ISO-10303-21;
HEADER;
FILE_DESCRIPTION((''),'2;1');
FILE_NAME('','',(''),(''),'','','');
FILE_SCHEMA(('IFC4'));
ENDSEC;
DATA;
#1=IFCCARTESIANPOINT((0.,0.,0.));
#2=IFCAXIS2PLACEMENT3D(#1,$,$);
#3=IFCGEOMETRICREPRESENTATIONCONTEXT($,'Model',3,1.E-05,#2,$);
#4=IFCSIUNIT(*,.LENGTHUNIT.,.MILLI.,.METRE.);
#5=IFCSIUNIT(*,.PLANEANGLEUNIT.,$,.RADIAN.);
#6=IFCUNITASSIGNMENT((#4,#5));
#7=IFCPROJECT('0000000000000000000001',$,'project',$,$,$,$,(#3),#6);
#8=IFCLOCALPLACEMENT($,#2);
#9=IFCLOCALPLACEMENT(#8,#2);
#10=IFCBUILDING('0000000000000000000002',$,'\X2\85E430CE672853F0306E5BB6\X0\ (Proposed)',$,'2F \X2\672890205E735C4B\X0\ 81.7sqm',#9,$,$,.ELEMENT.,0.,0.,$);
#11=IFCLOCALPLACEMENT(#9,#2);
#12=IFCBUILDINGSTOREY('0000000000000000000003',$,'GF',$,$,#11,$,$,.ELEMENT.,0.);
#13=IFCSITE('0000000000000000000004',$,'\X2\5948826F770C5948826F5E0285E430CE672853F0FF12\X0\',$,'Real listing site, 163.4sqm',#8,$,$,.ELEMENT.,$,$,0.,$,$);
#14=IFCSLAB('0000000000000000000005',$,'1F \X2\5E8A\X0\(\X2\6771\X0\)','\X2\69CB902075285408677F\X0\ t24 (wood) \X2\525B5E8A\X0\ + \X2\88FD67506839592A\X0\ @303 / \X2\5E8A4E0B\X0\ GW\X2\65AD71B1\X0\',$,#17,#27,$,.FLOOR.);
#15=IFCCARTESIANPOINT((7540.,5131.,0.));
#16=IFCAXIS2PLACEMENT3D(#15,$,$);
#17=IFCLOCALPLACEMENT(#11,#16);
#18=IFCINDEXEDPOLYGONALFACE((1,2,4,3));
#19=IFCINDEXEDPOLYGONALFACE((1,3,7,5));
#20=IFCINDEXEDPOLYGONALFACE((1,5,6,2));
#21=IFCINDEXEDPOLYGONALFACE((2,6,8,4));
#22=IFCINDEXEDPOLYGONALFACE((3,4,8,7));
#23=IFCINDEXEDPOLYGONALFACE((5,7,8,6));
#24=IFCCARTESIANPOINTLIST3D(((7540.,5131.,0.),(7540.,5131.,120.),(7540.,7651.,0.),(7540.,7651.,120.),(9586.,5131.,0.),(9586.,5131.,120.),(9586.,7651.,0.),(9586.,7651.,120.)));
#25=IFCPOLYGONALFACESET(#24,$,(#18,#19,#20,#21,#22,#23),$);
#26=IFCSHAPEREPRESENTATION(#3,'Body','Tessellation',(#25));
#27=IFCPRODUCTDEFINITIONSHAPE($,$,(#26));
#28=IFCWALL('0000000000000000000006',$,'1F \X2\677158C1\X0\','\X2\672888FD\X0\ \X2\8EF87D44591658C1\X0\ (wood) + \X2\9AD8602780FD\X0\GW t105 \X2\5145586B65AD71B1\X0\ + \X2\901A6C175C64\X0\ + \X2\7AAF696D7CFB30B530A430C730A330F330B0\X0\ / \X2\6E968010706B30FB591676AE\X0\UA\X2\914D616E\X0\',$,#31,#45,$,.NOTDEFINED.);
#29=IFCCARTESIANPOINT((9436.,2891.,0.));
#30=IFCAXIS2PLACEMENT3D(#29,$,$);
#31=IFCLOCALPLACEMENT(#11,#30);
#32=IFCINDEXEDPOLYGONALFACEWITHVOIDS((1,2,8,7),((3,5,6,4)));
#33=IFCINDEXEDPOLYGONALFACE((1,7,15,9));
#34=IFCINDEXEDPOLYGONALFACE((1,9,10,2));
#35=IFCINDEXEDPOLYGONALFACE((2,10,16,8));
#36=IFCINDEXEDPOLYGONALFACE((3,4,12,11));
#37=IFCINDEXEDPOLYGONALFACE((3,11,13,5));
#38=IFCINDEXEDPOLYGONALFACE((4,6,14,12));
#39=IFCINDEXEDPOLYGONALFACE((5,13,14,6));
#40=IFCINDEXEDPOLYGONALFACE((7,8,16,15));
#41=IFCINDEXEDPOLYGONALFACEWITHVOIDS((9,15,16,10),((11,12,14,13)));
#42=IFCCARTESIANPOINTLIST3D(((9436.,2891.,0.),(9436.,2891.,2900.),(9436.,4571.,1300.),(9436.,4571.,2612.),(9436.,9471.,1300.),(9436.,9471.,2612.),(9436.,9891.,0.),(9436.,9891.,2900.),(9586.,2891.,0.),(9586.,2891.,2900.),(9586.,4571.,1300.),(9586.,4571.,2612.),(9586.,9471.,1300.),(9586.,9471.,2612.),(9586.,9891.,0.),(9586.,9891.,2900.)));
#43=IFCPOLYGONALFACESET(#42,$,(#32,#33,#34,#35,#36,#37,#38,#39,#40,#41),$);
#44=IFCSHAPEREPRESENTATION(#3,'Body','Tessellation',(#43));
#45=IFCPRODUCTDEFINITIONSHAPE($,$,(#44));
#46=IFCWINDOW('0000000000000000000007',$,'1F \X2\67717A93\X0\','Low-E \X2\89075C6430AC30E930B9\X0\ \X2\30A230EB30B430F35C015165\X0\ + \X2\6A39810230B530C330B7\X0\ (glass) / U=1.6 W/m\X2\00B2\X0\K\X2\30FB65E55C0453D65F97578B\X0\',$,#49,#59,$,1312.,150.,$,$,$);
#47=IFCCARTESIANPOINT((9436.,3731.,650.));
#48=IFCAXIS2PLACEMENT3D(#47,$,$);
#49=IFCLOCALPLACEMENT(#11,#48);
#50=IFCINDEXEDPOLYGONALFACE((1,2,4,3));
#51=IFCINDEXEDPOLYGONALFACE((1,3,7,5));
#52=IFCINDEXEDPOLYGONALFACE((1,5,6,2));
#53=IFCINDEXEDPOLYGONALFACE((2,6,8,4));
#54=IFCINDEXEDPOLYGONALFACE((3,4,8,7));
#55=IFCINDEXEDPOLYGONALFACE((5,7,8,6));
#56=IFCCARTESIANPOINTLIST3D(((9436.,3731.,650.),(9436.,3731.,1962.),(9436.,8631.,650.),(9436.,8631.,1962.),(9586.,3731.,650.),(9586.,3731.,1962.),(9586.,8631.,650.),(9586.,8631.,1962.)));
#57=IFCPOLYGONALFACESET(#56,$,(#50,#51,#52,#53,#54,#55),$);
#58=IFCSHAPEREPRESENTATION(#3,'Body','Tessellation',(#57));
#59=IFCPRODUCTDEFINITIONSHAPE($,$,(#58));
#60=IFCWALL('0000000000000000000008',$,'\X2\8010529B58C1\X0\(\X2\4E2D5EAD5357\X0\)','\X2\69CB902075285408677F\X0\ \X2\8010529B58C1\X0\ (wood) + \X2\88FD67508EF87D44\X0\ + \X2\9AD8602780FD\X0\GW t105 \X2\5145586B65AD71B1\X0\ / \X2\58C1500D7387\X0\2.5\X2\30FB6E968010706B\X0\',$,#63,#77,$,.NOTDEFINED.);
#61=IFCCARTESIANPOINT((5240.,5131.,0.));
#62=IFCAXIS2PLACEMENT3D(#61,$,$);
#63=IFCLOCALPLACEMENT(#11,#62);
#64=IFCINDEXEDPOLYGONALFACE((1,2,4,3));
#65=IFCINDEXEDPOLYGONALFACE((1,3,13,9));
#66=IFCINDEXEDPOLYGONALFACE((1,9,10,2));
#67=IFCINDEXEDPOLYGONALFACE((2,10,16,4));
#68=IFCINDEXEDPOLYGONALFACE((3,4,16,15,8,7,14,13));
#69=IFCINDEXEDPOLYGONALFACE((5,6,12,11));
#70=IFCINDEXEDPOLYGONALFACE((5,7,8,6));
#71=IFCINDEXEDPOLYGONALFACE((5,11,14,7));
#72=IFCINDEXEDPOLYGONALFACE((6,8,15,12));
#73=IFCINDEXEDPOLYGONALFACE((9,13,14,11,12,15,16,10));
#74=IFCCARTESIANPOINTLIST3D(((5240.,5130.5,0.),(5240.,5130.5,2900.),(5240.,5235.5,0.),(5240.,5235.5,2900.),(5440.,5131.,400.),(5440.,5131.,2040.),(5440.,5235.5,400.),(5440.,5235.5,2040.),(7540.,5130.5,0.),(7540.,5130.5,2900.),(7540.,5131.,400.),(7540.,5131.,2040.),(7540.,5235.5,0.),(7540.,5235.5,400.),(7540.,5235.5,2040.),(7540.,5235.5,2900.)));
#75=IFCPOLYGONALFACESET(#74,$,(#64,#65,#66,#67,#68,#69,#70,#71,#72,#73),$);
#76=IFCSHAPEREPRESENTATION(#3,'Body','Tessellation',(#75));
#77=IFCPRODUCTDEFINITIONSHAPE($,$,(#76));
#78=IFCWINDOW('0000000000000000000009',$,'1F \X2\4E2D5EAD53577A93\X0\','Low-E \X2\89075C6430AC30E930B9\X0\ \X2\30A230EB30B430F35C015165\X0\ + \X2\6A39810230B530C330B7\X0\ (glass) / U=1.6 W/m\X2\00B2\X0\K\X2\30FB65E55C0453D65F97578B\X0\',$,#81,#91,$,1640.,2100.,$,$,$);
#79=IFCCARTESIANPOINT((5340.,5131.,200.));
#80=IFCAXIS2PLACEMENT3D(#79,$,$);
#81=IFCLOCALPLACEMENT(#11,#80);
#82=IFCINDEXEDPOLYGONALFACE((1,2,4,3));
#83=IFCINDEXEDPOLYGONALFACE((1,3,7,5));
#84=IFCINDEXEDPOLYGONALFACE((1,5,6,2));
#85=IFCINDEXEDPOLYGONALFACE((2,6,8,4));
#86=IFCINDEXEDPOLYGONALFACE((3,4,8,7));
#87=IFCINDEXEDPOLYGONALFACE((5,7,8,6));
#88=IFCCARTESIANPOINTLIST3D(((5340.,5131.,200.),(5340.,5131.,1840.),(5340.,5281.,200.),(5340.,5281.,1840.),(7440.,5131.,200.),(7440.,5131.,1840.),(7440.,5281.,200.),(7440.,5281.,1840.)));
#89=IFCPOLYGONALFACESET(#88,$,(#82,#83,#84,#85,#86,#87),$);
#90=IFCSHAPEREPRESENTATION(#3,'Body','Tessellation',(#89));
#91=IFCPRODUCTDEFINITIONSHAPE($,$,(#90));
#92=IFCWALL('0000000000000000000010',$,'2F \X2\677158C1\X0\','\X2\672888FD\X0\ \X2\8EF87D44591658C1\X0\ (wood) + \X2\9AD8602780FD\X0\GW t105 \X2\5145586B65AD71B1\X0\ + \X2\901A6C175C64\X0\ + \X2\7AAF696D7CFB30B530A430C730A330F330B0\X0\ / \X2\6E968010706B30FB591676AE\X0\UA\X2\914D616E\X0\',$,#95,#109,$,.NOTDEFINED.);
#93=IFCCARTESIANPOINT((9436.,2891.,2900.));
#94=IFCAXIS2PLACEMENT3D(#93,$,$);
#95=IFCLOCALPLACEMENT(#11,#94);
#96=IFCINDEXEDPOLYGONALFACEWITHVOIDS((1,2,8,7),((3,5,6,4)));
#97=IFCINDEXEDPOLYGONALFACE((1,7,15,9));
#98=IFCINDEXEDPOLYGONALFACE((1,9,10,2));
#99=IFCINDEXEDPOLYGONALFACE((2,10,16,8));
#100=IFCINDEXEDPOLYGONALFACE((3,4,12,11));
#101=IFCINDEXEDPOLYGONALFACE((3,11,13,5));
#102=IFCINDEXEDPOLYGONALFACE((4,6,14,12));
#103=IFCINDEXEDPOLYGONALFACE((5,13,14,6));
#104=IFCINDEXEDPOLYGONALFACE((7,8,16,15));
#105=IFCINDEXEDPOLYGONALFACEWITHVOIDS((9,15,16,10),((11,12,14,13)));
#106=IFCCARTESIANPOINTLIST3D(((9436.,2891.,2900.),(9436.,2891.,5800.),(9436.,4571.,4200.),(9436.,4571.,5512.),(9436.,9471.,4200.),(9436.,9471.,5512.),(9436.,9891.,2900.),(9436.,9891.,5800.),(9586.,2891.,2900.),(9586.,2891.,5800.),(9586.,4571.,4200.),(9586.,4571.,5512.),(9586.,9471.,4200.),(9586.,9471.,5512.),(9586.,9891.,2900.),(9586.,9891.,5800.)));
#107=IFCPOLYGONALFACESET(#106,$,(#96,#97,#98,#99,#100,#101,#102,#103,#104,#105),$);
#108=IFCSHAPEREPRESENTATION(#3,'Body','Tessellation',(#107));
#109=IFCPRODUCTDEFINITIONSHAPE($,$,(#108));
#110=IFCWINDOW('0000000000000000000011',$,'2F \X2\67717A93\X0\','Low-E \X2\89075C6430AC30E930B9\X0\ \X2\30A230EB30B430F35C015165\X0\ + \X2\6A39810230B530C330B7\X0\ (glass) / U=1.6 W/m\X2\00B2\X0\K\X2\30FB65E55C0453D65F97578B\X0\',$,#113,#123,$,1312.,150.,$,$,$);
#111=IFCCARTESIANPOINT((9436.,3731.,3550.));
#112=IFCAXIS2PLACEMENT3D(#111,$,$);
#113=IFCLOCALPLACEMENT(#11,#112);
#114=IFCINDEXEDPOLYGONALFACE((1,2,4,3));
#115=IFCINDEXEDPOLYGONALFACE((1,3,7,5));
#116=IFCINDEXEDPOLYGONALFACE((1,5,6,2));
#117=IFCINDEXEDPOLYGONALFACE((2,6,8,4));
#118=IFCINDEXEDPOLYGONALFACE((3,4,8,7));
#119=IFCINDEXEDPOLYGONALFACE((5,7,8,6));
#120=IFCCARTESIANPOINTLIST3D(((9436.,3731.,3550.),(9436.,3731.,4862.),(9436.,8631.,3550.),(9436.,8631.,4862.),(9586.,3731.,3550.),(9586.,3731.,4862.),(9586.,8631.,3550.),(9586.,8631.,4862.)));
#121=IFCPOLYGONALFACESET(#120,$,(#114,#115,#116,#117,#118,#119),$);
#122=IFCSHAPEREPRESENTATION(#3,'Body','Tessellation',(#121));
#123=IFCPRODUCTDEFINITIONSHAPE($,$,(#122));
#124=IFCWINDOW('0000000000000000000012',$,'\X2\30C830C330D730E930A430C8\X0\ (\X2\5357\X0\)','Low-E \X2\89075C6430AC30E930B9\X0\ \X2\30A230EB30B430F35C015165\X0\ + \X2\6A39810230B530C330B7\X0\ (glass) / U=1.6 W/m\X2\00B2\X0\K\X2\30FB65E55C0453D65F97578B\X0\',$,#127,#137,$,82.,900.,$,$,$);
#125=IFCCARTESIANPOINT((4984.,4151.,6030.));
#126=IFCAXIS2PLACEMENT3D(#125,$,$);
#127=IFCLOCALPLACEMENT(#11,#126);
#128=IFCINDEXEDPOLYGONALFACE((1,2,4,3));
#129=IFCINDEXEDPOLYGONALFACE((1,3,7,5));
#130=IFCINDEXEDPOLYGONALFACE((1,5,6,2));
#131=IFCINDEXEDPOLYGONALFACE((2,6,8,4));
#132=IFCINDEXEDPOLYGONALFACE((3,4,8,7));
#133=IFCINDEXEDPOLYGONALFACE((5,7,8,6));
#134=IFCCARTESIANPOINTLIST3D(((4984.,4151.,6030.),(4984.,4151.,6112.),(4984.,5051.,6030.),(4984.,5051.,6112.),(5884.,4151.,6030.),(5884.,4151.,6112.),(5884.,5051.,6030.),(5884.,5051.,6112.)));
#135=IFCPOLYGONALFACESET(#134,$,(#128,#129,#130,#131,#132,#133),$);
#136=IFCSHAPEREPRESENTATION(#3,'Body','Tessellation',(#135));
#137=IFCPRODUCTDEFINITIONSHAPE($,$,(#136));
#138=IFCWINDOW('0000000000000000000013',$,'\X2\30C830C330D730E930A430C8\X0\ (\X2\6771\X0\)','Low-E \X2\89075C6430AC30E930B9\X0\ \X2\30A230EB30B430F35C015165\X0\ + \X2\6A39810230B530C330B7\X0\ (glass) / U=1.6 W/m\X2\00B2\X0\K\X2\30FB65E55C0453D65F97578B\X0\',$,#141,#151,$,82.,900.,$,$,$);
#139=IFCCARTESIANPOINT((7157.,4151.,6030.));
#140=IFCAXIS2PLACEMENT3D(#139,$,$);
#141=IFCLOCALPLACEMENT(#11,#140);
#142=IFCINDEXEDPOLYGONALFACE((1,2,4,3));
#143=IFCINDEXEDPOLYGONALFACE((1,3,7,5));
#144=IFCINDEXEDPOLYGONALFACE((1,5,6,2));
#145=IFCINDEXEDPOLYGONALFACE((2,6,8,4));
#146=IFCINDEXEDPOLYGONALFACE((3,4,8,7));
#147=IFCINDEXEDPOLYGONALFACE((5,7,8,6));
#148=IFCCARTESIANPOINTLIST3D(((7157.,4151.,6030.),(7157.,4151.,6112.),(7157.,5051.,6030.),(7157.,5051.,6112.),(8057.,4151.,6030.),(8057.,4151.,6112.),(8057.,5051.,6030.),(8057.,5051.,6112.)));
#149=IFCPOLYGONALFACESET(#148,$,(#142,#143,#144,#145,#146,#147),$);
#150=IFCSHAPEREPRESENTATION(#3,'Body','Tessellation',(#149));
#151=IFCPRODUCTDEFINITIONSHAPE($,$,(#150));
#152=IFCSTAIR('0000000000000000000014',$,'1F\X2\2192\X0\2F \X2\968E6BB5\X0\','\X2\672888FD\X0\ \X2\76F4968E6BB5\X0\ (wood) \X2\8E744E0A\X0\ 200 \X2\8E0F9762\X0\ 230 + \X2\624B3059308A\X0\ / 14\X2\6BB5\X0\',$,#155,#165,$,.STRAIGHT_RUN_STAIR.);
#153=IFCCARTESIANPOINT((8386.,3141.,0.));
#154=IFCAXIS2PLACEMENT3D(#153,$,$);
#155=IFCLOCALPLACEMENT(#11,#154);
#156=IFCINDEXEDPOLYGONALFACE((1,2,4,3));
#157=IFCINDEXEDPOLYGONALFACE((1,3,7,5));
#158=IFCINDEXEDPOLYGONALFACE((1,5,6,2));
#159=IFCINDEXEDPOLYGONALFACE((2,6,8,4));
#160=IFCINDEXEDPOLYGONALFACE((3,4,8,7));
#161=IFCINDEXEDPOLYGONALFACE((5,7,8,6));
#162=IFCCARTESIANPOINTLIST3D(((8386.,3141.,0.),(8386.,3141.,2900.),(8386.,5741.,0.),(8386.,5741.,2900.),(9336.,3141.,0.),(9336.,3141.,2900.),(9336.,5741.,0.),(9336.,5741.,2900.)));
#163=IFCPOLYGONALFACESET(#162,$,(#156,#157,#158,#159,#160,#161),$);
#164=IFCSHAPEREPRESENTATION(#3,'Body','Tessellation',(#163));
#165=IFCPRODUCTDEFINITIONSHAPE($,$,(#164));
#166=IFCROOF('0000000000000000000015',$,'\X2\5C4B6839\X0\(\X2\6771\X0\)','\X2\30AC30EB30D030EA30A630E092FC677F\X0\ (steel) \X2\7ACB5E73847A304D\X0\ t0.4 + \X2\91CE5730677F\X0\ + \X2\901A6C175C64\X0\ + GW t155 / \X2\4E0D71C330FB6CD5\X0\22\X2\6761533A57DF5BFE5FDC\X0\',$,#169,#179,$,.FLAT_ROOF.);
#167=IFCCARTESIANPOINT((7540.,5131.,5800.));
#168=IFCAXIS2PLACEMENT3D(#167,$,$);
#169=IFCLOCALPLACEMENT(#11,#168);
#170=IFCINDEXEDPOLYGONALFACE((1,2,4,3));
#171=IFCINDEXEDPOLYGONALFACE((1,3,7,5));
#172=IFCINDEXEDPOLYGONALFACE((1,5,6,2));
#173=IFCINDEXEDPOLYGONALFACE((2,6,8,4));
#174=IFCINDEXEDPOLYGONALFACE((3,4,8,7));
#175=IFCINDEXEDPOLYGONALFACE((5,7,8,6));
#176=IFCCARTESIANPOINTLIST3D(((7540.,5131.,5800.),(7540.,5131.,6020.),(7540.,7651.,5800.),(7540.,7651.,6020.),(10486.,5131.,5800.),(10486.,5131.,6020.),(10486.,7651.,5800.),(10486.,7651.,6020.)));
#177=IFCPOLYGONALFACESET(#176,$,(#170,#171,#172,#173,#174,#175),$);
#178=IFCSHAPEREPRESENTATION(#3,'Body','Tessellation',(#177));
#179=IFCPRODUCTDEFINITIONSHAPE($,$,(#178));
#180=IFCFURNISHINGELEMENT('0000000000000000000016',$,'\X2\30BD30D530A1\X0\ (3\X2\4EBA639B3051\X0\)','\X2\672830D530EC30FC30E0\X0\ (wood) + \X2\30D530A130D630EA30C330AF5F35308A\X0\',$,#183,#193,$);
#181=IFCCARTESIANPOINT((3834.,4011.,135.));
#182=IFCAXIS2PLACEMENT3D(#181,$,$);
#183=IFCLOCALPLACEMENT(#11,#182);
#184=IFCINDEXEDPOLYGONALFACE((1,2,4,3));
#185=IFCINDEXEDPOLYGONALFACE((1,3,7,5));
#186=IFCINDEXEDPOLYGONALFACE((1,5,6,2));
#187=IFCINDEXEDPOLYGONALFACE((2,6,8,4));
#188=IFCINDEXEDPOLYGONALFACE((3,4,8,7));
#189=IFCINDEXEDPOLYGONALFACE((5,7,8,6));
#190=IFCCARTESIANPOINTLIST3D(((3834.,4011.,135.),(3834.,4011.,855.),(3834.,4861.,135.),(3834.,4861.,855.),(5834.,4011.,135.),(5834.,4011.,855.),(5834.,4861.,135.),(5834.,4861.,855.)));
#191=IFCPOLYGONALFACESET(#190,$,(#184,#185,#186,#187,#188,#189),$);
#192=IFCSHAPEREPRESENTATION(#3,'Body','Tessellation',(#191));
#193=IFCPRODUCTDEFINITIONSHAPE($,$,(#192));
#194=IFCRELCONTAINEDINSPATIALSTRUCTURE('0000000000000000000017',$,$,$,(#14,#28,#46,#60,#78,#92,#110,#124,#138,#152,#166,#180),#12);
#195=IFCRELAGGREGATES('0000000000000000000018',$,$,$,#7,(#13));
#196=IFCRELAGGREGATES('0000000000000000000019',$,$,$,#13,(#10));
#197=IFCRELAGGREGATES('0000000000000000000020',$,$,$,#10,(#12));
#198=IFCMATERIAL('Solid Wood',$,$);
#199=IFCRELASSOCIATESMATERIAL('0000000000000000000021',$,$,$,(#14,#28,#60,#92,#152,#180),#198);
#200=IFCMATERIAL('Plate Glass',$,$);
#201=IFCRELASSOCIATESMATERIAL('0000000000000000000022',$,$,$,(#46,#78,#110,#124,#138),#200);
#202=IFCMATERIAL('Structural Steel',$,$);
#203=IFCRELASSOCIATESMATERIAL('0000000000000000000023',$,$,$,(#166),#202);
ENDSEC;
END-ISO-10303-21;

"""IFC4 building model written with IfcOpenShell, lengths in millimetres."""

from ifc_helpers import new_model, si_unit, frame, frame_2d, origin, place, context, project, spatial, rectangle, extrude, material, element, fill, save


model = new_model("IFC4")

# Units and contexts
model_context = context("Model", 3, precision=1e-05, world=origin())
ifc_project = project(units=[si_unit("LENGTHUNIT", "METRE", prefix="MILLI"), si_unit("PLANEANGLEUNIT", "RADIAN")], contexts=[model_context])

# Site, building, storey
site_placement = place(None, origin())
site = spatial("IfcSite", under=ifc_project, at=site_placement, Name="奈良県奈良市藤ノ木台２", ObjectType="Real listing site, 163.4sqm", CompositionType="ELEMENT", RefElevation=0.0)
building_placement = place(site_placement, origin())
building = spatial("IfcBuilding", under=site, at=building_placement, Name="藤ノ木台の家 (Proposed)", ObjectType="2F 木造平屋 81.7sqm", CompositionType="ELEMENT", ElevationOfRefHeight=0.0, ElevationOfTerrain=0.0)
storey_placement = place(building_placement, origin())
storey = spatial("IfcBuildingStorey", under=building, at=storey_placement, Name="GF", CompositionType="ELEMENT", Elevation=0.0)

# Slab
ifc_material_1 = material(Name="Solid Wood")
slab_placement = place(storey_placement, frame((7540.0, 5131.0, 0.0)))
element("IfcSlab", 1, at=slab_placement, inside=storey, material=ifc_material_1, Name="1F 床(東)", Description="構造用合板 t24 (wood) 剛床 + 製材根太 @303 / 床下 GW断熱", PredefinedType="FLOOR", context=model_context, shape_type="SweptSolid", body=[
    extrude(rectangle(XDim=2046.0, YDim=2520.0, at=frame_2d((1023.0, 1260.0))), frame((7540.0, 5131.0, 0.0)), (0.0, 0.0, 1.0), 120.0),
])

# Walls, openings, windows
wall_1_placement = place(storey_placement, frame((9436.0, 2891.0, 0.0)))
wall_1 = element("IfcWall", 2, at=wall_1_placement, inside=storey, material=ifc_material_1, Name="1F 東壁", Description="木製 軸組外壁 (wood) + 高性能GW t105 充填断熱 + 通気層 + 窯業系サイディング / 準耐火・外皮UA配慮", PredefinedType="NOTDEFINED", context=model_context, shape_type="SweptSolid", body=[
    extrude(rectangle(XDim=150.0, YDim=7000.0, at=frame_2d((75.0, 3500.0))), frame((9436.0, 2891.0, 0.0)), (0.0, 0.0, 1.0), 2900.0),
])
opening_1_placement = place(storey_placement, frame((9436.0, 3731.0, 650.0)))
opening_1 = element("IfcOpeningElement", 3, at=opening_1_placement, cuts=wall_1, PredefinedType="NOTDEFINED", context=model_context, shape_type="SweptSolid", body=[
    extrude(rectangle(XDim=150.0, YDim=4900.0, at=frame_2d((75.0, 2450.0))), frame((9436.0, 3731.0, 650.0)), (0.0, 0.0, 1.0), 1312.0),
])
ifc_material_2 = material(Name="Plate Glass")
window_1_placement = place(storey_placement, frame((9436.0, 3731.0, 650.0)))
window_1 = element("IfcWindow", 4, at=window_1_placement, inside=storey, material=ifc_material_2, Name="1F 東窓", Description="Low-E 複層ガラス アルゴン封入 + 樹脂サッシ (glass) / U=1.6 W/m²K・日射取得型", OverallHeight=1312.0, OverallWidth=150.0, context=model_context, shape_type="SweptSolid", body=[
    extrude(rectangle(XDim=150.0, YDim=4900.0, at=frame_2d((75.0, 2450.0))), frame((9436.0, 3731.0, 650.0)), (0.0, 0.0, 1.0), 1312.0),
])
fill(opening_1, window_1)
wall_2_placement = place(storey_placement, frame((5240.0, 5131.0, 0.0)))
wall_2 = element("IfcWall", 5, at=wall_2_placement, inside=storey, material=ifc_material_1, Name="耐力壁(中庭南)", Description="構造用合板 耐力壁 (wood) + 製材軸組 + 高性能GW t105 充填断熱 / 壁倍率2.5・準耐火", PredefinedType="NOTDEFINED", context=model_context, shape_type="SweptSolid", body=[
    extrude(rectangle(XDim=2300.0, YDim=105.0, at=frame_2d((1150.0, 52.0))), frame((5240.0, 5131.0, 0.0)), (0.0, 0.0, 1.0), 2900.0),
])
opening_2_placement = place(storey_placement, frame((5340.0, 5131.0, 200.0)))
opening_2 = element("IfcOpeningElement", 6, at=opening_2_placement, cuts=wall_2, PredefinedType="NOTDEFINED", context=model_context, shape_type="SweptSolid", body=[
    extrude(rectangle(XDim=2100.0, YDim=150.0, at=frame_2d((1050.0, 75.0))), frame((5340.0, 5131.0, 200.0)), (0.0, 0.0, 1.0), 1640.0),
])
window_2_placement = place(storey_placement, frame((5340.0, 5131.0, 200.0)))
window_2 = element("IfcWindow", 7, at=window_2_placement, inside=storey, material=ifc_material_2, Name="1F 中庭南窓", Description="Low-E 複層ガラス アルゴン封入 + 樹脂サッシ (glass) / U=1.6 W/m²K・日射取得型", OverallHeight=1640.0, OverallWidth=2100.0, context=model_context, shape_type="SweptSolid", body=[
    extrude(rectangle(XDim=2100.0, YDim=150.0, at=frame_2d((1050.0, 75.0))), frame((5340.0, 5131.0, 200.0)), (0.0, 0.0, 1.0), 1640.0),
])
fill(opening_2, window_2)

# Wall, opening, window
wall_3_placement = place(storey_placement, frame((9436.0, 2891.0, 2900.0)))
wall_3 = element("IfcWall", 8, at=wall_3_placement, inside=storey, material=ifc_material_1, Name="2F 東壁", Description="木製 軸組外壁 (wood) + 高性能GW t105 充填断熱 + 通気層 + 窯業系サイディング / 準耐火・外皮UA配慮", PredefinedType="NOTDEFINED", context=model_context, shape_type="SweptSolid", body=[
    extrude(rectangle(XDim=150.0, YDim=7000.0, at=frame_2d((75.0, 3500.0))), frame((9436.0, 2891.0, 2900.0)), (0.0, 0.0, 1.0), 2900.0),
])
opening_3_placement = place(storey_placement, frame((9436.0, 3731.0, 3550.0)))
opening_3 = element("IfcOpeningElement", 9, at=opening_3_placement, cuts=wall_3, PredefinedType="NOTDEFINED", context=model_context, shape_type="SweptSolid", body=[
    extrude(rectangle(XDim=150.0, YDim=4900.0, at=frame_2d((75.0, 2450.0))), frame((9436.0, 3731.0, 3550.0)), (0.0, 0.0, 1.0), 1312.0),
])
window_3_placement = place(storey_placement, frame((9436.0, 3731.0, 3550.0)))
window_3 = element("IfcWindow", 10, at=window_3_placement, inside=storey, material=ifc_material_2, Name="2F 東窓", Description="Low-E 複層ガラス アルゴン封入 + 樹脂サッシ (glass) / U=1.6 W/m²K・日射取得型", OverallHeight=1312.0, OverallWidth=150.0, context=model_context, shape_type="SweptSolid", body=[
    extrude(rectangle(XDim=150.0, YDim=4900.0, at=frame_2d((75.0, 2450.0))), frame((9436.0, 3731.0, 3550.0)), (0.0, 0.0, 1.0), 1312.0),
])
fill(opening_3, window_3)

# Windows
window_4_placement = place(storey_placement, frame((4984.0, 4151.0, 6030.0)))
element("IfcWindow", 11, at=window_4_placement, inside=storey, material=ifc_material_2, Name="トップライト (南)", Description="Low-E 複層ガラス アルゴン封入 + 樹脂サッシ (glass) / U=1.6 W/m²K・日射取得型", OverallHeight=82.0, OverallWidth=900.0, context=model_context, shape_type="SweptSolid", body=[
    extrude(rectangle(XDim=900.0, YDim=900.0, at=frame_2d((450.0, 450.0))), frame((4984.0, 4151.0, 6030.0)), (0.0, 0.0, 1.0), 82.0),
])
window_5_placement = place(storey_placement, frame((7157.0, 4151.0, 6030.0)))
element("IfcWindow", 12, at=window_5_placement, inside=storey, material=ifc_material_2, Name="トップライト (東)", Description="Low-E 複層ガラス アルゴン封入 + 樹脂サッシ (glass) / U=1.6 W/m²K・日射取得型", OverallHeight=82.0, OverallWidth=900.0, context=model_context, shape_type="SweptSolid", body=[
    extrude(rectangle(XDim=900.0, YDim=900.0, at=frame_2d((450.0, 450.0))), frame((7157.0, 4151.0, 6030.0)), (0.0, 0.0, 1.0), 82.0),
])

# Stair
stair_placement = place(storey_placement, frame((8386.0, 3141.0, 0.0)))
element("IfcStair", 13, at=stair_placement, inside=storey, material=ifc_material_1, Name="1F→2F 階段", Description="木製 直階段 (wood) 蹴上 200 踏面 230 + 手すり / 14段", PredefinedType="STRAIGHT_RUN_STAIR", context=model_context, shape_type="SweptSolid", body=[
    extrude(rectangle(XDim=950.0, YDim=2600.0, at=frame_2d((475.0, 1300.0))), frame((8386.0, 3141.0, 0.0)), (0.0, 0.0, 1.0), 2900.0),
])

# Roof
ifc_material_3 = material(Name="Structural Steel")
roof_placement = place(storey_placement, frame((7540.0, 5131.0, 5800.0)))
element("IfcRoof", 14, at=roof_placement, inside=storey, material=ifc_material_3, Name="屋根(東)", Description="ガルバリウム鋼板 (steel) 立平葺き t0.4 + 野地板 + 通気層 + GW t155 / 不燃・法22条区域対応", PredefinedType="FLAT_ROOF", context=model_context, shape_type="SweptSolid", body=[
    extrude(rectangle(XDim=2946.0, YDim=2520.0, at=frame_2d((1473.0, 1260.0))), frame((7540.0, 5131.0, 5800.0)), (0.0, 0.0, 1.0), 220.0),
])

# Furnishing element
furnishing_1_placement = place(storey_placement, frame((3834.0, 4011.0, 135.0)))
element("IfcFurnishingElement", 15, at=furnishing_1_placement, inside=storey, material=ifc_material_1, Name="ソファ (3人掛け)", Description="木フレーム (wood) + ファブリック張り", context=model_context, shape_type="SweptSolid", body=[
    extrude(rectangle(XDim=2000.0, YDim=850.0, at=frame_2d((1000.0, 425.0))), frame((3834.0, 4011.0, 135.0)), (0.0, 0.0, 1.0), 720.0),
])

save(model, "model.ifc")
